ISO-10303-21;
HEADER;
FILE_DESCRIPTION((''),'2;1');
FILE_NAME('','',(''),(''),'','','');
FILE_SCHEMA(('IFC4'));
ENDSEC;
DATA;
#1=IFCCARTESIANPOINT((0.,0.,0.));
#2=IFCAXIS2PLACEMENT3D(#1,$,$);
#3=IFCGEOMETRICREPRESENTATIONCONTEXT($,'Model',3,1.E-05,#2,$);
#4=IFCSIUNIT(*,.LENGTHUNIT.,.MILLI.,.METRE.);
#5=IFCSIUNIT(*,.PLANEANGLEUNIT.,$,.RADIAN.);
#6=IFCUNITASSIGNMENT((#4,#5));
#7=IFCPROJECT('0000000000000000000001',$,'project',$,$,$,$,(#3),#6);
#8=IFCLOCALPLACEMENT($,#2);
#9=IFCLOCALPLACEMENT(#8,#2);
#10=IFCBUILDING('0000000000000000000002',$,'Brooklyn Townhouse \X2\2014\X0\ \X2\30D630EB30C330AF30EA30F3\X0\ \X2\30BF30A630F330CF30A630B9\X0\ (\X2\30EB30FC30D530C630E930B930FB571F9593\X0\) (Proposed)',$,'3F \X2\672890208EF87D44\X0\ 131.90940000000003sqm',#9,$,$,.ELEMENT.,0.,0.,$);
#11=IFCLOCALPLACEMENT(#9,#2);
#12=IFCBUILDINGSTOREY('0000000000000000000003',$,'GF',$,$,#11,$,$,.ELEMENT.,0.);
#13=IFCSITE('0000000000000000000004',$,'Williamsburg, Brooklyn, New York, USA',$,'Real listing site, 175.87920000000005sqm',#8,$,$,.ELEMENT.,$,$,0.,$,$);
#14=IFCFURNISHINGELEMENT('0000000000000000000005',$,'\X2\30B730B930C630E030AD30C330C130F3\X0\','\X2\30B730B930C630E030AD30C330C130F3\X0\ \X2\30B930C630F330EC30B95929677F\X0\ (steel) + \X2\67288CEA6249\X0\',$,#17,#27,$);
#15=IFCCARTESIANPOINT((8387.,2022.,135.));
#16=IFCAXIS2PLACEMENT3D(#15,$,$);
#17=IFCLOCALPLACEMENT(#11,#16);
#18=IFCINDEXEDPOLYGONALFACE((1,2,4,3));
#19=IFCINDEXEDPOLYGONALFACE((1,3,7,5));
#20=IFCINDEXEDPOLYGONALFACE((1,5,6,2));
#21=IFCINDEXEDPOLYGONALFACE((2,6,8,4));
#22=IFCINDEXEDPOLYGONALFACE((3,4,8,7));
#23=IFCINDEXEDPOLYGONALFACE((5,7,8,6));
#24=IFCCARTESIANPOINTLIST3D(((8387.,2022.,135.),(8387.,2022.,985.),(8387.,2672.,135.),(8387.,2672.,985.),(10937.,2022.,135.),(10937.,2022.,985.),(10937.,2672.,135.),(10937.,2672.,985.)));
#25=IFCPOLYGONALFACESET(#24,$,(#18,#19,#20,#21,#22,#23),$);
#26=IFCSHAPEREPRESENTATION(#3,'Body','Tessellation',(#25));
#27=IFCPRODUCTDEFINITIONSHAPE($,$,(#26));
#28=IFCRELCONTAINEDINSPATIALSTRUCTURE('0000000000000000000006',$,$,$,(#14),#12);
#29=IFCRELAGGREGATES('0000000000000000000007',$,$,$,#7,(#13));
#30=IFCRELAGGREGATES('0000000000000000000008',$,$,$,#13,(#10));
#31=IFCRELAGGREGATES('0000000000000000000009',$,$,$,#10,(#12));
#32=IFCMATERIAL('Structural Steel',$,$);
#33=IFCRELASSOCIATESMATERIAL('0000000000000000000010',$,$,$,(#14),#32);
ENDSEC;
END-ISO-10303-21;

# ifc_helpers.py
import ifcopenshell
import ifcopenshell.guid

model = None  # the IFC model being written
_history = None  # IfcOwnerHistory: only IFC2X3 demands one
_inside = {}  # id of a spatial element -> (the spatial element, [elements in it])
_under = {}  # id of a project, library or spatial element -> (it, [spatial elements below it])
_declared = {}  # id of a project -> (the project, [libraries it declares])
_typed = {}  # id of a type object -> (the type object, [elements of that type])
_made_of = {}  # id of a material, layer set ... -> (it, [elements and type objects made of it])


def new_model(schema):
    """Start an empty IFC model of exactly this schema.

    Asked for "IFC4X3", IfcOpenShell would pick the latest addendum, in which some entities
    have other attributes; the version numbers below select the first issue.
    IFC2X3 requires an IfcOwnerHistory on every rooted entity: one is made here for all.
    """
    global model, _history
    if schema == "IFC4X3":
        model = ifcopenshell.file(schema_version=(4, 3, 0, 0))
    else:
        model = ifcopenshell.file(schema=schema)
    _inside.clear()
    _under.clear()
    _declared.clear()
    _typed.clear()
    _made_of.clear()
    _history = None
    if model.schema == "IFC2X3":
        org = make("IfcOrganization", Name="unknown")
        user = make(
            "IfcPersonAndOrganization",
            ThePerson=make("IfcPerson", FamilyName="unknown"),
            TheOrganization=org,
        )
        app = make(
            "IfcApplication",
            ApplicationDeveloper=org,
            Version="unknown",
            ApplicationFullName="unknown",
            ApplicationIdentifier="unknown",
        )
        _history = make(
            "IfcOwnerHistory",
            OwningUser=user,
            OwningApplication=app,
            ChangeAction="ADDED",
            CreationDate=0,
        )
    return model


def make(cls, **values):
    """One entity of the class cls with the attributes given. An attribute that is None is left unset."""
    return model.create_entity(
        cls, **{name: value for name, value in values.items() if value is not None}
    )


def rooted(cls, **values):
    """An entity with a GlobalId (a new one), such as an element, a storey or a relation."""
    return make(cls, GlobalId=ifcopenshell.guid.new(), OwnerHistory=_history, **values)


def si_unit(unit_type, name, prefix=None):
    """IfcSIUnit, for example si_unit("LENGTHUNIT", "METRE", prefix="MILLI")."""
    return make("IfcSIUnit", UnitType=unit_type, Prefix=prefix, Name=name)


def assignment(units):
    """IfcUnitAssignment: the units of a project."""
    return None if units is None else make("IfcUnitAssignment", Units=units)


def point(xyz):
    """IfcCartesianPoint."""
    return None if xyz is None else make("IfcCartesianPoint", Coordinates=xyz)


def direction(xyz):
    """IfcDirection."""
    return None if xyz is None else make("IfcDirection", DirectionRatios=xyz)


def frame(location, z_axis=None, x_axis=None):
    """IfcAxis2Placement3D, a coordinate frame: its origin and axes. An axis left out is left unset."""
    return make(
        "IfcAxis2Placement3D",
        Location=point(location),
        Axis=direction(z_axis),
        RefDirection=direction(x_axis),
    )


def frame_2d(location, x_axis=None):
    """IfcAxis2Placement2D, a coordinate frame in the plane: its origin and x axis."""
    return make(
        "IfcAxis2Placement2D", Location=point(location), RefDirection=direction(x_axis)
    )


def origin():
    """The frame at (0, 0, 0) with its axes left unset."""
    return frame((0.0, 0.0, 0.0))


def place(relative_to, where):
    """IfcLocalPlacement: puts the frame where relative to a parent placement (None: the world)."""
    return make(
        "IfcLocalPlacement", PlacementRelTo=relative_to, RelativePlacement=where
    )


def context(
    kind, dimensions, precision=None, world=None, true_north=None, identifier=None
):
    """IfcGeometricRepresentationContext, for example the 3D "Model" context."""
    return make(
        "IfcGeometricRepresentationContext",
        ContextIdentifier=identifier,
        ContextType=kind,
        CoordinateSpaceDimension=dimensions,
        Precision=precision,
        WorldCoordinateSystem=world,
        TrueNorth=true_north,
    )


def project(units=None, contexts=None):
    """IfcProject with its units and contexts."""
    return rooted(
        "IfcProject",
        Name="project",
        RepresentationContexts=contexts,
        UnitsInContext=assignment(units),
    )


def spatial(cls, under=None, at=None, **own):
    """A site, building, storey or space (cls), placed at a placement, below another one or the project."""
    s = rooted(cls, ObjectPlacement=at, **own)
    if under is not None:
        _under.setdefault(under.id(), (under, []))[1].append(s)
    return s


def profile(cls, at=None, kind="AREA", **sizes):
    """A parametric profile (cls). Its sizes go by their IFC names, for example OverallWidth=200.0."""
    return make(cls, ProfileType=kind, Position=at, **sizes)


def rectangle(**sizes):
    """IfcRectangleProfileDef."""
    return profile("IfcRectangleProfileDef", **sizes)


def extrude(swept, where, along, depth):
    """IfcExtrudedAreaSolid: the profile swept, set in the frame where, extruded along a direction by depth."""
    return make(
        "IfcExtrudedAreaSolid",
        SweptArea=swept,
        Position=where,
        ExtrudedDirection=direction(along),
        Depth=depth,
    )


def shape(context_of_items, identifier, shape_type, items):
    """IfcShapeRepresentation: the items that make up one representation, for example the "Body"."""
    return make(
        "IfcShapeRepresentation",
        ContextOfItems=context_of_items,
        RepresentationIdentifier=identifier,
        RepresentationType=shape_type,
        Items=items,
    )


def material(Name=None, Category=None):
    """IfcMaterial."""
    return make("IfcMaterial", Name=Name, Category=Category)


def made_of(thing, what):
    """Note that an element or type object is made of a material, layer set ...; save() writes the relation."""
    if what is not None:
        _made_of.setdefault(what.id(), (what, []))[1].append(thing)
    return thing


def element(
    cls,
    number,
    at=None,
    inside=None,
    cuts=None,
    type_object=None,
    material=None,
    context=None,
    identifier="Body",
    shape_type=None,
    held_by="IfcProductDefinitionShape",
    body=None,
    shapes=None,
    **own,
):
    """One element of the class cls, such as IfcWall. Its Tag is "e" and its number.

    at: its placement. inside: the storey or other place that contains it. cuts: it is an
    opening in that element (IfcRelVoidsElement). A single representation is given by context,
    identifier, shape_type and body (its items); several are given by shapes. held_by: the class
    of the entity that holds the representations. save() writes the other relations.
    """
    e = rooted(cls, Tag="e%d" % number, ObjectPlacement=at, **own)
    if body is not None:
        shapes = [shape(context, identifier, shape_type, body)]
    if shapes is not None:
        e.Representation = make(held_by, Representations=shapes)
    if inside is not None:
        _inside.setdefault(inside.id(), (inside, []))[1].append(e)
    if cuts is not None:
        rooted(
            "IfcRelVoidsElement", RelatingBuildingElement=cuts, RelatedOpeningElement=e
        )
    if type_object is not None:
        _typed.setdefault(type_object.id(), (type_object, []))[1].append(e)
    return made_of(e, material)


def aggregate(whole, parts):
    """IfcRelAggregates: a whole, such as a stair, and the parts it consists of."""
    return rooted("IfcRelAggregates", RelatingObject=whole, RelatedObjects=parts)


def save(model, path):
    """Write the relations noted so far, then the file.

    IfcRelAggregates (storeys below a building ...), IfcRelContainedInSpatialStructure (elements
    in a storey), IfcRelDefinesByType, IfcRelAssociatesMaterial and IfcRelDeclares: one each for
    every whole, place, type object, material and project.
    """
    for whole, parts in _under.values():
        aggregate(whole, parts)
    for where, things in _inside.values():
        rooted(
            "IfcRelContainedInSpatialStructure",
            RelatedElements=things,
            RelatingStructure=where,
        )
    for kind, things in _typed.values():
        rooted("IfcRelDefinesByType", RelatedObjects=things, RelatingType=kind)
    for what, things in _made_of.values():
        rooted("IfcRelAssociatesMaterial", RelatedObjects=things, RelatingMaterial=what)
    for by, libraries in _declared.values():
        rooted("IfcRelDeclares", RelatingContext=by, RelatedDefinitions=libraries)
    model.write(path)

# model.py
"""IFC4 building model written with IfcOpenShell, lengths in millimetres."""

from ifc_helpers import new_model, si_unit, frame, frame_2d, origin, place, context, project, spatial, rectangle, extrude, material, element, save


model = new_model("IFC4")

# Units and contexts
model_context = context("Model", 3, precision=1e-05, world=origin())
ifc_project = project(units=[si_unit("LENGTHUNIT", "METRE", prefix="MILLI"), si_unit("PLANEANGLEUNIT", "RADIAN")], contexts=[model_context])

# Site, building, storey
site_placement = place(None, origin())
site = spatial("IfcSite", under=ifc_project, at=site_placement, Name="Williamsburg, Brooklyn, New York, USA", ObjectType="Real listing site, 175.87920000000005sqm", CompositionType="ELEMENT", RefElevation=0.0)
building_placement = place(site_placement, origin())
building = spatial("IfcBuilding", under=site, at=building_placement, Name="Brooklyn Townhouse — ブルックリン タウンハウス (ルーフテラス・土間) (Proposed)", ObjectType="3F 木造軸組 131.90940000000003sqm", CompositionType="ELEMENT", ElevationOfRefHeight=0.0, ElevationOfTerrain=0.0)
storey_placement = place(building_placement, origin())
storey = spatial("IfcBuildingStorey", under=building, at=storey_placement, Name="GF", CompositionType="ELEMENT", Elevation=0.0)

# Furnishing element
ifc_material_1 = material(Name="Structural Steel")
furnishing_1_placement = place(storey_placement, frame((8387.0, 2022.0, 135.0)))
element("IfcFurnishingElement", 1, at=furnishing_1_placement, inside=storey, material=ifc_material_1, Name="システムキッチン", Description="システムキッチン ステンレス天板 (steel) + 木質扉", context=model_context, shape_type="SweptSolid", body=[
    extrude(rectangle(XDim=2550.0, YDim=650.0, at=frame_2d((1275.0, 325.0))), frame((8387.0, 2022.0, 135.0)), (0.0, 0.0, 1.0), 850.0),
])

save(model, "model.ifc")
